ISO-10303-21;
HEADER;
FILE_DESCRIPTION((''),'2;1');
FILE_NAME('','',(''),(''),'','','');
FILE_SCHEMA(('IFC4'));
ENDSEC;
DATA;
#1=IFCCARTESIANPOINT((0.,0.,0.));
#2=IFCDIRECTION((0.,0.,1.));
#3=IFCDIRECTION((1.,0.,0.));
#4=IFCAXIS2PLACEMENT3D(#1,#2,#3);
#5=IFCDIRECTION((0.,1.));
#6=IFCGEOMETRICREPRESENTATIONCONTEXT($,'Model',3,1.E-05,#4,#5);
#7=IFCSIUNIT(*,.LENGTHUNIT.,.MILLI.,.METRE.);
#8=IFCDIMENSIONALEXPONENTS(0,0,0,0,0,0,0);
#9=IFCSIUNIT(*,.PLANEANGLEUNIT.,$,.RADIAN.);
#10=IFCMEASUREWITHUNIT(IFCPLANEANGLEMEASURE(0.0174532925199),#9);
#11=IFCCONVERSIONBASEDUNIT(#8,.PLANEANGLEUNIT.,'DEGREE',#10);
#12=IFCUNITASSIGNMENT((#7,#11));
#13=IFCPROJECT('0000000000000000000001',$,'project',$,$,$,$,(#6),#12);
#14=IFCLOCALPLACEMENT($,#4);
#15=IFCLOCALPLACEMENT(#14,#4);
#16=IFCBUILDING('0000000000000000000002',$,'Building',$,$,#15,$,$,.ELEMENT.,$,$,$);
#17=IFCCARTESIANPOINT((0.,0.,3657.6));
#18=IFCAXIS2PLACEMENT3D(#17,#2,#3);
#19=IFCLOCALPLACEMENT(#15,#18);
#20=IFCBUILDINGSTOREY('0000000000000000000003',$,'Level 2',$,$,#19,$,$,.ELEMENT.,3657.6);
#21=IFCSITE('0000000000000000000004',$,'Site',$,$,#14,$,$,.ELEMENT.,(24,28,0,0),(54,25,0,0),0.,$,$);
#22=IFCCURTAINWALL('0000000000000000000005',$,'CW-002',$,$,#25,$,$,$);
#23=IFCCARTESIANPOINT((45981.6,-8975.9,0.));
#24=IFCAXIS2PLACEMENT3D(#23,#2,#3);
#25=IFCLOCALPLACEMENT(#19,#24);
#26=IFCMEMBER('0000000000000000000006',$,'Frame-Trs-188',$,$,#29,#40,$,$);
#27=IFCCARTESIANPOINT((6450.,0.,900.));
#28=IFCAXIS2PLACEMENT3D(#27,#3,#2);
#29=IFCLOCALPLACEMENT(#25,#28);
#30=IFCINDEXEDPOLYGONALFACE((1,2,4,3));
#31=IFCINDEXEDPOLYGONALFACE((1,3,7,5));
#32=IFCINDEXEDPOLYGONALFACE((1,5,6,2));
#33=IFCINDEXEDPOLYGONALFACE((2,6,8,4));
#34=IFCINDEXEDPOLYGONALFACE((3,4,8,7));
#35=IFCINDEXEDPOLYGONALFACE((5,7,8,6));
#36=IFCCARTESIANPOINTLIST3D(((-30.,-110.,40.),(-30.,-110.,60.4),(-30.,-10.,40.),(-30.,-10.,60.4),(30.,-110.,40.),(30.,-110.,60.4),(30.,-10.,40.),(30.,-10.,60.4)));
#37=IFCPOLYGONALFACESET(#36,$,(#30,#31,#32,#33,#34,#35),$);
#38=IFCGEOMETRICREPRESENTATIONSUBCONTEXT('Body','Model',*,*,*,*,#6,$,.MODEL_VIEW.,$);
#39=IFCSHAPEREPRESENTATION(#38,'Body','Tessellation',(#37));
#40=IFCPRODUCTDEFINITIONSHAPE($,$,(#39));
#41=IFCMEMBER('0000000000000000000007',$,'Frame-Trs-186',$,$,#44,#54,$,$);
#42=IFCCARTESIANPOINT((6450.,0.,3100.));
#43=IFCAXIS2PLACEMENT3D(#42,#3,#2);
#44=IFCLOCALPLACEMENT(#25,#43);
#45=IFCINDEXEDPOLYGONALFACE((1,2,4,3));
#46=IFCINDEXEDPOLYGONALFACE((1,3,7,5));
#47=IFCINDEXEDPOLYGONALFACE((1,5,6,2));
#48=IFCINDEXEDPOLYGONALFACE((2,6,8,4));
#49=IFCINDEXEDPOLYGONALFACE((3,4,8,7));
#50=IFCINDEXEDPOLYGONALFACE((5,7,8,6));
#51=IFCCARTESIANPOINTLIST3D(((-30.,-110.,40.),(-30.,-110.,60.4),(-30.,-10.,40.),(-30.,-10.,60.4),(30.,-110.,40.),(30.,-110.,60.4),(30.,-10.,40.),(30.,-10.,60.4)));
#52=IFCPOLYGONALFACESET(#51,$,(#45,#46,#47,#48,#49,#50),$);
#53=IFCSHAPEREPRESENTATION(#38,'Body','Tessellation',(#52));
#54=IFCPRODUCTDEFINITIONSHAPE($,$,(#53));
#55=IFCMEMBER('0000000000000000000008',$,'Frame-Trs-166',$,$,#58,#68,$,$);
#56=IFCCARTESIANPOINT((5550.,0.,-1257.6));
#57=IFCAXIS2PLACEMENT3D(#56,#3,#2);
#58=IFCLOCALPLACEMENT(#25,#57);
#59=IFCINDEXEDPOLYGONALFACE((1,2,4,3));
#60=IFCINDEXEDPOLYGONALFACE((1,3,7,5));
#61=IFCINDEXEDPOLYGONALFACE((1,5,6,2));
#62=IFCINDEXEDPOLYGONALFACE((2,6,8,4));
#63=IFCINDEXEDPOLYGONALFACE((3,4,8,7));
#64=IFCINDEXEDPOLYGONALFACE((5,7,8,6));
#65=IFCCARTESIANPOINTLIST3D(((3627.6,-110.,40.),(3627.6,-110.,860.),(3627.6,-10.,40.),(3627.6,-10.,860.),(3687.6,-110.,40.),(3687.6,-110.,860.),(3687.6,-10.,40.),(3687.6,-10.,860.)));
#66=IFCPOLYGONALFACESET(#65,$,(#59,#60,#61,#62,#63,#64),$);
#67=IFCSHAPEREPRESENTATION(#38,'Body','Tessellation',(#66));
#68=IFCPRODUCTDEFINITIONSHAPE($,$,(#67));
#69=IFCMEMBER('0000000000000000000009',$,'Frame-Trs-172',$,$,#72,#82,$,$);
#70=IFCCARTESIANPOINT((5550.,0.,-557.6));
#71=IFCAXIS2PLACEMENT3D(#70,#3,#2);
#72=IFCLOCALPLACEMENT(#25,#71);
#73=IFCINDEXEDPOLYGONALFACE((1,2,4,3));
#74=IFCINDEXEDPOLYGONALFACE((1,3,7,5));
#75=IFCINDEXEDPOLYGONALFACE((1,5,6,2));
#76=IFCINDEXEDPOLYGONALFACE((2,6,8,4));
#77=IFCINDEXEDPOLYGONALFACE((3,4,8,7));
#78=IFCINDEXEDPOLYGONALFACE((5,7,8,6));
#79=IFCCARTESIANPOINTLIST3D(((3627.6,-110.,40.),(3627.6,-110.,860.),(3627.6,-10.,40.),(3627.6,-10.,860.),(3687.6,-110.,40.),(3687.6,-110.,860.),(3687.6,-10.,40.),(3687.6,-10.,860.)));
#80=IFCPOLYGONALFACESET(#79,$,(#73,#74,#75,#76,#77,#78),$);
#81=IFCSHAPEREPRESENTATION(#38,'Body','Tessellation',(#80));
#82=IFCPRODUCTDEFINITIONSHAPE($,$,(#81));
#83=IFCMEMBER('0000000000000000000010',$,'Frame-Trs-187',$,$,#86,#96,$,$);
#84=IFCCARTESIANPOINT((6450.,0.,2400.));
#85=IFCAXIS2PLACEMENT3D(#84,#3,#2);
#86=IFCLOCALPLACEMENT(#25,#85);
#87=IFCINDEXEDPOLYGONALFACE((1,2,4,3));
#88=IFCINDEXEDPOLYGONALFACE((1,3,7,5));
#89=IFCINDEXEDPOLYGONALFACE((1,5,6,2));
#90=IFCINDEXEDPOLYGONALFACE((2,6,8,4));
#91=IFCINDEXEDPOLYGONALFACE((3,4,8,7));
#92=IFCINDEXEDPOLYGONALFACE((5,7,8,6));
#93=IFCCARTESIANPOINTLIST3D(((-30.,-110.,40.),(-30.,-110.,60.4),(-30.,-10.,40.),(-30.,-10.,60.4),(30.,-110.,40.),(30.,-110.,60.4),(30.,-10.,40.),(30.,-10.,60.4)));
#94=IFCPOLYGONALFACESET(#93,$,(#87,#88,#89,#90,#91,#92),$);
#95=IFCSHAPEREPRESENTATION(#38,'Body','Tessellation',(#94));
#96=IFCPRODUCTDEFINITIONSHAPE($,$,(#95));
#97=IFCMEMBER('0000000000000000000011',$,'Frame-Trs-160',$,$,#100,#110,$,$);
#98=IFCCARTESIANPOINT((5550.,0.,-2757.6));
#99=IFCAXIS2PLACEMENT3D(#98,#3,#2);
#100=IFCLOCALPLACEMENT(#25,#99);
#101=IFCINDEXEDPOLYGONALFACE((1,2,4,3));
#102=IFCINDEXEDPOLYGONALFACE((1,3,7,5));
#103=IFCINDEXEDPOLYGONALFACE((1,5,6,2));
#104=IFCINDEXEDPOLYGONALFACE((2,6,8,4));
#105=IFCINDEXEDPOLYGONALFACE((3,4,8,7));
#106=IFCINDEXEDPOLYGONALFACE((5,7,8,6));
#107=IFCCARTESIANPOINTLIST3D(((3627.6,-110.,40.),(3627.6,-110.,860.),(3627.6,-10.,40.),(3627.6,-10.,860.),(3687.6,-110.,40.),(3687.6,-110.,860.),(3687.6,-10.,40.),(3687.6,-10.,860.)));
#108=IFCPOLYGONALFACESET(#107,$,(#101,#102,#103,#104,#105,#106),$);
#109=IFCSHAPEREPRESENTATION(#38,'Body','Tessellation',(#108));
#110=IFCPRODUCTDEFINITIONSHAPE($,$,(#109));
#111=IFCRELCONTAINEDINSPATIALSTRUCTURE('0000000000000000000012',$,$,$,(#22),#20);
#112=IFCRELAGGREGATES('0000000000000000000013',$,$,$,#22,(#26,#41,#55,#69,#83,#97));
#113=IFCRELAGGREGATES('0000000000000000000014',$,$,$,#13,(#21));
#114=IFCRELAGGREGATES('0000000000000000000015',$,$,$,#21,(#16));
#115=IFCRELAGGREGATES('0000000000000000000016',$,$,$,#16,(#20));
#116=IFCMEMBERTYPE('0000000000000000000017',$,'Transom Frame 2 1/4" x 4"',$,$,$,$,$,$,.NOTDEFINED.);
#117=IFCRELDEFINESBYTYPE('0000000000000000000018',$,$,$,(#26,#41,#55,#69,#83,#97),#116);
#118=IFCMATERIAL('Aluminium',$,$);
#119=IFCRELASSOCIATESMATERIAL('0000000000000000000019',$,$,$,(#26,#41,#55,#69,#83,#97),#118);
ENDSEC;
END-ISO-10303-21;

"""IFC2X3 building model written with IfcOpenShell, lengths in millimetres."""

from ifc_helpers import new_model, entity, si_unit, converted_unit, direction, frame, origin_with_axes, place, context, subcontext, project, spatial, polyline, outline, extrude, material, type_object, element, aggregate, save


model = new_model("IFC2X3")

# Units and contexts
model_context = context("Model", 3, precision=1e-05, world=origin_with_axes(), true_north=direction((0.0, 1.0)))
body_context = subcontext(model_context, "Body", "Model", "MODEL_VIEW")
ifc_project = project(units=[si_unit("LENGTHUNIT", "METRE", prefix="MILLI"), converted_unit("PLANEANGLEUNIT", "DEGREE", entity("IfcPlaneAngleMeasure", 0.0174532925199), si_unit("PLANEANGLEUNIT", "RADIAN"), dimensions=[0, 0, 0, 0, 0, 0, 0])], contexts=[model_context])

# Site, building, storey
site_placement = place(None, origin_with_axes())
site = spatial("IfcSite", under=ifc_project, at=site_placement, Name="Site", CompositionType="ELEMENT", RefLatitude=(24, 28, 0, 0), RefLongitude=(54, 25, 0, 0), RefElevation=0.0)
building_placement = place(site_placement, origin_with_axes())
building = spatial("IfcBuilding", under=site, at=building_placement, Name="Building", CompositionType="ELEMENT")
storey_placement = place(building_placement, frame((0.0, 0.0, 3657.6), z_axis=(0.0, 0.0, 1.0), x_axis=(1.0, 0.0, 0.0)))
storey = spatial("IfcBuildingStorey", under=building, at=storey_placement, Name="Level 2", CompositionType="ELEMENT", Elevation=3657.6)

# Curtain wall, members
curtain_wall_placement = place(storey_placement, frame((45981.6, -8975.9, 0.0), z_axis=(0.0, 0.0, 1.0), x_axis=(1.0, 0.0, 0.0)))
curtain_wall = element("IfcCurtainWall", 1, at=curtain_wall_placement, inside=storey, Name="CW-002")
ifc_material_1 = material(Name="Aluminium")
member_type_1 = type_object("IfcMemberType", Name="Transom Frame 2 1/4\" x 4\"", PredefinedType="NOTDEFINED")
member_1_placement = place(curtain_wall_placement, frame((6450.0, 0.0, 900.0), z_axis=(1.0, 0.0, 0.0), x_axis=(0.0, 0.0, 1.0)))
member_1 = element("IfcMember", 2, at=member_1_placement, type_object=member_type_1, material=ifc_material_1, Name="Frame-Trs-188", context=body_context, shape_type="SweptSolid", body=[
    extrude(outline(polyline([(-110.0, -30.0), (-10.0, -30.0), (-10.0, 30.0), (-110.0, 30.0), (-110.0, -30.0)])), frame((0.0, 0.0, 40.0), z_axis=(0.0, 0.0, 1.0), x_axis=(0.0, 1.0, 0.0)), (0.0, 0.0, 1.0), 20.4),
])
member_2_placement = place(curtain_wall_placement, frame((6450.0, 0.0, 3100.0), z_axis=(1.0, 0.0, 0.0), x_axis=(0.0, 0.0, 1.0)))
member_2 = element("IfcMember", 3, at=member_2_placement, type_object=member_type_1, material=ifc_material_1, Name="Frame-Trs-186", context=body_context, shape_type="SweptSolid", body=[
    extrude(outline(polyline([(-110.0, -30.0), (-10.0, -30.0), (-10.0, 30.0), (-110.0, 30.0), (-110.0, -30.0)])), frame((0.0, 0.0, 40.0), z_axis=(0.0, 0.0, 1.0), x_axis=(0.0, 1.0, 0.0)), (0.0, 0.0, 1.0), 20.4),
])
member_3_placement = place(curtain_wall_placement, frame((5550.0, 0.0, -1257.6), z_axis=(1.0, 0.0, 0.0), x_axis=(0.0, 0.0, 1.0)))
member_3 = element("IfcMember", 4, at=member_3_placement, type_object=member_type_1, material=ifc_material_1, Name="Frame-Trs-166", context=body_context, shape_type="SweptSolid", body=[
    extrude(outline(polyline([(-110.0, -3687.6), (-10.0, -3687.6), (-10.0, -3627.6), (-110.0, -3627.6), (-110.0, -3687.6)])), frame((0.0, 0.0, 40.0), z_axis=(0.0, 0.0, 1.0), x_axis=(0.0, 1.0, 0.0)), (0.0, 0.0, 1.0), 820.0),
])
member_4_placement = place(curtain_wall_placement, frame((5550.0, 0.0, -557.6), z_axis=(1.0, 0.0, 0.0), x_axis=(0.0, 0.0, 1.0)))
member_4 = element("IfcMember", 5, at=member_4_placement, type_object=member_type_1, material=ifc_material_1, Name="Frame-Trs-172", context=body_context, shape_type="SweptSolid", body=[
    extrude(outline(polyline([(-110.0, -3687.6), (-10.0, -3687.6), (-10.0, -3627.6), (-110.0, -3627.6), (-110.0, -3687.6)])), frame((0.0, 0.0, 40.0), z_axis=(0.0, 0.0, 1.0), x_axis=(0.0, 1.0, 0.0)), (0.0, 0.0, 1.0), 820.0),
])
member_5_placement = place(curtain_wall_placement, frame((6450.0, 0.0, 2400.0), z_axis=(1.0, 0.0, 0.0), x_axis=(0.0, 0.0, 1.0)))
member_5 = element("IfcMember", 6, at=member_5_placement, type_object=member_type_1, material=ifc_material_1, Name="Frame-Trs-187", context=body_context, shape_type="SweptSolid", body=[
    extrude(outline(polyline([(-110.0, -30.0), (-10.0, -30.0), (-10.0, 30.0), (-110.0, 30.0), (-110.0, -30.0)])), frame((0.0, 0.0, 40.0), z_axis=(0.0, 0.0, 1.0), x_axis=(0.0, 1.0, 0.0)), (0.0, 0.0, 1.0), 20.4),
])
member_6_placement = place(curtain_wall_placement, frame((5550.0, 0.0, -2757.6), z_axis=(1.0, 0.0, 0.0), x_axis=(0.0, 0.0, 1.0)))
member_6 = element("IfcMember", 7, at=member_6_placement, type_object=member_type_1, material=ifc_material_1, Name="Frame-Trs-160", context=body_context, shape_type="SweptSolid", body=[
    extrude(outline(polyline([(-110.0, -3687.6), (-10.0, -3687.6), (-10.0, -3627.6), (-110.0, -3627.6), (-110.0, -3687.6)])), frame((0.0, 0.0, 40.0), z_axis=(0.0, 0.0, 1.0), x_axis=(0.0, 1.0, 0.0)), (0.0, 0.0, 1.0), 820.0),
])
aggregate(curtain_wall, [member_1, member_2, member_3, member_4, member_5, member_6])

save(model, "model.ifc")
